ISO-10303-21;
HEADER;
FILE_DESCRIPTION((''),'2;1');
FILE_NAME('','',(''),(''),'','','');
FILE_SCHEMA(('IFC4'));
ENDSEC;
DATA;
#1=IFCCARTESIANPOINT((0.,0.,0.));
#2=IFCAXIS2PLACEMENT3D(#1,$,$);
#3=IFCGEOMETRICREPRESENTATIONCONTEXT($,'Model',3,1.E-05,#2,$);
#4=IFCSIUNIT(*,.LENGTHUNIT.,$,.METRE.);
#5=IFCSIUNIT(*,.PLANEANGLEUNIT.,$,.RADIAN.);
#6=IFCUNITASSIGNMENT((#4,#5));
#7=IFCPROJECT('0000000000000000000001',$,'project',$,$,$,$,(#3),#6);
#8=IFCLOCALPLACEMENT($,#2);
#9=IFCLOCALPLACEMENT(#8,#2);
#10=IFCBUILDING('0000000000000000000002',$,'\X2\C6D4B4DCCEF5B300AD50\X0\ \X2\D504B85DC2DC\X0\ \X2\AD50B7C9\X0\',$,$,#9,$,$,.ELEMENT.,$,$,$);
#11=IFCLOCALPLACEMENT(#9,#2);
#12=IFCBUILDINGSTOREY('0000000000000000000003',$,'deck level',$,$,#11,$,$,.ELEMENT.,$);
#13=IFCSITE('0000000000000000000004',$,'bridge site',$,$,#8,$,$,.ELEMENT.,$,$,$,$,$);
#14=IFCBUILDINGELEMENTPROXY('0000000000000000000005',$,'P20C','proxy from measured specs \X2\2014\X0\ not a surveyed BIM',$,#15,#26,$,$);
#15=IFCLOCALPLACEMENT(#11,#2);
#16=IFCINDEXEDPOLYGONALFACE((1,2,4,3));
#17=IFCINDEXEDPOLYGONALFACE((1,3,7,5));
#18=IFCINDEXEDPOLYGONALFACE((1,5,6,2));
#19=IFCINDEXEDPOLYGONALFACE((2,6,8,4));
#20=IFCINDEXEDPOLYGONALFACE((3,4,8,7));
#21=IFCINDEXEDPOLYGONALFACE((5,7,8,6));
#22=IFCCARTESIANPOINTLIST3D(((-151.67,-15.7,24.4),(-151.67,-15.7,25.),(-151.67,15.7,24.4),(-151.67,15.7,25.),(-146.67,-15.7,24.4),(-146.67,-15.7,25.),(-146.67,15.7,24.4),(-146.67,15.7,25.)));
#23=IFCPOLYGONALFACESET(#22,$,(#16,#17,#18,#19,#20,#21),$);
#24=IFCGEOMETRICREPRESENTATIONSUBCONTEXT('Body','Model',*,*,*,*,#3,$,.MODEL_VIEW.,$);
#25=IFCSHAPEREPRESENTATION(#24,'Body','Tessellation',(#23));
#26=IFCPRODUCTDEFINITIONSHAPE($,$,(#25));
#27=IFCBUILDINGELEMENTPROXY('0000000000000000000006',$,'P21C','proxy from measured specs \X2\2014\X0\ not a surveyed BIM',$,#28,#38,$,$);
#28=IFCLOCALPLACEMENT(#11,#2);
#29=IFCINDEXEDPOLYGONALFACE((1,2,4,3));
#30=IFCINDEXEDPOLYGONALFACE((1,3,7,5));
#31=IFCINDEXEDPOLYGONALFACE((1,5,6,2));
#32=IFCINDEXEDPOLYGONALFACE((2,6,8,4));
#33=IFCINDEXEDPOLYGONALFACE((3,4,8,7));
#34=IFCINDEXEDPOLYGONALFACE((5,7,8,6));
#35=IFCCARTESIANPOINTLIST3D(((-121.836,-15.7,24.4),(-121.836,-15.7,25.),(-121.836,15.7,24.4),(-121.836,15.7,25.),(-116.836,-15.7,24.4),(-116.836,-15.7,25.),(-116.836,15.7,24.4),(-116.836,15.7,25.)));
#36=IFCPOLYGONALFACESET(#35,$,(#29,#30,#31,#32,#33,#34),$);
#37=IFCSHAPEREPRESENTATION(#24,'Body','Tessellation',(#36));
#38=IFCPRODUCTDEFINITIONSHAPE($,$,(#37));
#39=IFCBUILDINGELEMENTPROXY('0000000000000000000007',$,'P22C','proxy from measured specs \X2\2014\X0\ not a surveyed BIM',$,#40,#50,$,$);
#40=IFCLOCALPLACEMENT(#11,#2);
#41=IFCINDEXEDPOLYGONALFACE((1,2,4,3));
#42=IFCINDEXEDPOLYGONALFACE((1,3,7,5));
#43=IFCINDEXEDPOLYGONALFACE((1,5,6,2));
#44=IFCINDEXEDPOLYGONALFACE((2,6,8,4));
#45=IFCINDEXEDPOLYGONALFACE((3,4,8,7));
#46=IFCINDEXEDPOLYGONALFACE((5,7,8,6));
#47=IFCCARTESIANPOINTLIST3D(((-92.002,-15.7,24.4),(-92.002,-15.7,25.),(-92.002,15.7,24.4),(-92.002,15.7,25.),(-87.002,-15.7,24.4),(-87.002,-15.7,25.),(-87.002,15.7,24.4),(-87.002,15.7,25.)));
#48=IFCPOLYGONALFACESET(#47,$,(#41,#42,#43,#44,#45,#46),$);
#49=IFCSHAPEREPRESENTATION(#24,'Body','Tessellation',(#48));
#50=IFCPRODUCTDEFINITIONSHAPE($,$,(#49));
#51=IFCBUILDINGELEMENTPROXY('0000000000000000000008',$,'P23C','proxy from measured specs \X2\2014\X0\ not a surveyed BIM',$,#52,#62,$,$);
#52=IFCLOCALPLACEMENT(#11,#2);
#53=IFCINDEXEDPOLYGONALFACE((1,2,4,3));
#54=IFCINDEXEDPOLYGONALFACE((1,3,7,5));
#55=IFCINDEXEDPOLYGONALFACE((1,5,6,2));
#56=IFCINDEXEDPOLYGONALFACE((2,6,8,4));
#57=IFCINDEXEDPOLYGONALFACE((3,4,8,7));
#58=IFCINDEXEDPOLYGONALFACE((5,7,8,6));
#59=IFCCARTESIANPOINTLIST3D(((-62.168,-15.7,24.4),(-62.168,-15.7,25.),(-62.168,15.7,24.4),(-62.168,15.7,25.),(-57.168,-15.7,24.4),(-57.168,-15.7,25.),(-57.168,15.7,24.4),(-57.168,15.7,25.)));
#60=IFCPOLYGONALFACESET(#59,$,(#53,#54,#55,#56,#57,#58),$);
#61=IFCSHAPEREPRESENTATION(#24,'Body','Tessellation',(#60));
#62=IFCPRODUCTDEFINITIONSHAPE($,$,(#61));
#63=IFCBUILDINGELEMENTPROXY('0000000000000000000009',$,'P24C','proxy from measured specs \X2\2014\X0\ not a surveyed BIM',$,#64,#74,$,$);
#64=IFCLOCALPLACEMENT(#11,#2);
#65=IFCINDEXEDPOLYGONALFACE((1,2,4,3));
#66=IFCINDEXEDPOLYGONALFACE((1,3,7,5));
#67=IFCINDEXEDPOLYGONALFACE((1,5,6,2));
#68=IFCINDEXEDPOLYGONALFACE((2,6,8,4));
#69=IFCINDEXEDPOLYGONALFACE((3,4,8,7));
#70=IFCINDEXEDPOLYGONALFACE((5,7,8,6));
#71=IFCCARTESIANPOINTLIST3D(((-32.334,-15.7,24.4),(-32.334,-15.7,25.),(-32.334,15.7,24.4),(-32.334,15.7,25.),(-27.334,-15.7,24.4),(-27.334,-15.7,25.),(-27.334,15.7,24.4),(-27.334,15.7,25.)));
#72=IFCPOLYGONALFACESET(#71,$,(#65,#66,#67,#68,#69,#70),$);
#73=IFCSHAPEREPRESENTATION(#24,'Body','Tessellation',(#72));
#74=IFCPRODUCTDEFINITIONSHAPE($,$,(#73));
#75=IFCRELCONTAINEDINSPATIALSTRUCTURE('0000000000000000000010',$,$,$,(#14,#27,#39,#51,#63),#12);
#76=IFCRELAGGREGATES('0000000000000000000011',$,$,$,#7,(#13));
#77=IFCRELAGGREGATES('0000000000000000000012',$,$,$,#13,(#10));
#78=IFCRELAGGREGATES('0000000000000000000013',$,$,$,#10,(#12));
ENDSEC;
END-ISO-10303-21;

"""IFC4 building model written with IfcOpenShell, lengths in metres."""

from ifc_helpers import new_model, si_unit, frame, origin, origin_2d, place, context, subcontext, project, spatial, rectangle, extrude, element, save


model = new_model("IFC4")

# Units and contexts
model_context = context("Model", 3, precision=1e-05, world=origin())
body_context = subcontext(model_context, "Body", "Model", "MODEL_VIEW")
ifc_project = project(units=[si_unit("LENGTHUNIT", "METRE"), si_unit("PLANEANGLEUNIT", "RADIAN")], contexts=[model_context])

# Site, building, storey
site_placement = place(None, origin())
site = spatial("IfcSite", under=ifc_project, at=site_placement, Name="bridge site", CompositionType="ELEMENT")
building_placement = place(site_placement, origin())
building = spatial("IfcBuilding", under=site, at=building_placement, Name="월드컵대교 프록시 교량", CompositionType="ELEMENT")
storey_placement = place(building_placement, origin())
storey = spatial("IfcBuildingStorey", under=building, at=storey_placement, Name="deck level", CompositionType="ELEMENT")

# Building element proxies
for number, where, name in (
    (1, (-149.17, 0.0, 24.4), "P20C"),
    (2, (-119.336, 0.0, 24.4), "P21C"),
    (3, (-89.502, 0.0, 24.4), "P22C"),
    (4, (-59.668, 0.0, 24.4), "P23C"),
    (5, (-29.834, 0.0, 24.4), "P24C"),
):
    element("IfcBuildingElementProxy", number, at=place(storey_placement, frame(where)), inside=storey, Name=name, Description="proxy from measured specs — not a surveyed BIM", context=body_context, shape_type="SweptSolid", body=[
        extrude(rectangle(XDim=5.0, YDim=31.4, at=origin_2d()), origin(), (0.0, 0.0, 1.0), 0.6),
    ])

save(model, "model.ifc")
